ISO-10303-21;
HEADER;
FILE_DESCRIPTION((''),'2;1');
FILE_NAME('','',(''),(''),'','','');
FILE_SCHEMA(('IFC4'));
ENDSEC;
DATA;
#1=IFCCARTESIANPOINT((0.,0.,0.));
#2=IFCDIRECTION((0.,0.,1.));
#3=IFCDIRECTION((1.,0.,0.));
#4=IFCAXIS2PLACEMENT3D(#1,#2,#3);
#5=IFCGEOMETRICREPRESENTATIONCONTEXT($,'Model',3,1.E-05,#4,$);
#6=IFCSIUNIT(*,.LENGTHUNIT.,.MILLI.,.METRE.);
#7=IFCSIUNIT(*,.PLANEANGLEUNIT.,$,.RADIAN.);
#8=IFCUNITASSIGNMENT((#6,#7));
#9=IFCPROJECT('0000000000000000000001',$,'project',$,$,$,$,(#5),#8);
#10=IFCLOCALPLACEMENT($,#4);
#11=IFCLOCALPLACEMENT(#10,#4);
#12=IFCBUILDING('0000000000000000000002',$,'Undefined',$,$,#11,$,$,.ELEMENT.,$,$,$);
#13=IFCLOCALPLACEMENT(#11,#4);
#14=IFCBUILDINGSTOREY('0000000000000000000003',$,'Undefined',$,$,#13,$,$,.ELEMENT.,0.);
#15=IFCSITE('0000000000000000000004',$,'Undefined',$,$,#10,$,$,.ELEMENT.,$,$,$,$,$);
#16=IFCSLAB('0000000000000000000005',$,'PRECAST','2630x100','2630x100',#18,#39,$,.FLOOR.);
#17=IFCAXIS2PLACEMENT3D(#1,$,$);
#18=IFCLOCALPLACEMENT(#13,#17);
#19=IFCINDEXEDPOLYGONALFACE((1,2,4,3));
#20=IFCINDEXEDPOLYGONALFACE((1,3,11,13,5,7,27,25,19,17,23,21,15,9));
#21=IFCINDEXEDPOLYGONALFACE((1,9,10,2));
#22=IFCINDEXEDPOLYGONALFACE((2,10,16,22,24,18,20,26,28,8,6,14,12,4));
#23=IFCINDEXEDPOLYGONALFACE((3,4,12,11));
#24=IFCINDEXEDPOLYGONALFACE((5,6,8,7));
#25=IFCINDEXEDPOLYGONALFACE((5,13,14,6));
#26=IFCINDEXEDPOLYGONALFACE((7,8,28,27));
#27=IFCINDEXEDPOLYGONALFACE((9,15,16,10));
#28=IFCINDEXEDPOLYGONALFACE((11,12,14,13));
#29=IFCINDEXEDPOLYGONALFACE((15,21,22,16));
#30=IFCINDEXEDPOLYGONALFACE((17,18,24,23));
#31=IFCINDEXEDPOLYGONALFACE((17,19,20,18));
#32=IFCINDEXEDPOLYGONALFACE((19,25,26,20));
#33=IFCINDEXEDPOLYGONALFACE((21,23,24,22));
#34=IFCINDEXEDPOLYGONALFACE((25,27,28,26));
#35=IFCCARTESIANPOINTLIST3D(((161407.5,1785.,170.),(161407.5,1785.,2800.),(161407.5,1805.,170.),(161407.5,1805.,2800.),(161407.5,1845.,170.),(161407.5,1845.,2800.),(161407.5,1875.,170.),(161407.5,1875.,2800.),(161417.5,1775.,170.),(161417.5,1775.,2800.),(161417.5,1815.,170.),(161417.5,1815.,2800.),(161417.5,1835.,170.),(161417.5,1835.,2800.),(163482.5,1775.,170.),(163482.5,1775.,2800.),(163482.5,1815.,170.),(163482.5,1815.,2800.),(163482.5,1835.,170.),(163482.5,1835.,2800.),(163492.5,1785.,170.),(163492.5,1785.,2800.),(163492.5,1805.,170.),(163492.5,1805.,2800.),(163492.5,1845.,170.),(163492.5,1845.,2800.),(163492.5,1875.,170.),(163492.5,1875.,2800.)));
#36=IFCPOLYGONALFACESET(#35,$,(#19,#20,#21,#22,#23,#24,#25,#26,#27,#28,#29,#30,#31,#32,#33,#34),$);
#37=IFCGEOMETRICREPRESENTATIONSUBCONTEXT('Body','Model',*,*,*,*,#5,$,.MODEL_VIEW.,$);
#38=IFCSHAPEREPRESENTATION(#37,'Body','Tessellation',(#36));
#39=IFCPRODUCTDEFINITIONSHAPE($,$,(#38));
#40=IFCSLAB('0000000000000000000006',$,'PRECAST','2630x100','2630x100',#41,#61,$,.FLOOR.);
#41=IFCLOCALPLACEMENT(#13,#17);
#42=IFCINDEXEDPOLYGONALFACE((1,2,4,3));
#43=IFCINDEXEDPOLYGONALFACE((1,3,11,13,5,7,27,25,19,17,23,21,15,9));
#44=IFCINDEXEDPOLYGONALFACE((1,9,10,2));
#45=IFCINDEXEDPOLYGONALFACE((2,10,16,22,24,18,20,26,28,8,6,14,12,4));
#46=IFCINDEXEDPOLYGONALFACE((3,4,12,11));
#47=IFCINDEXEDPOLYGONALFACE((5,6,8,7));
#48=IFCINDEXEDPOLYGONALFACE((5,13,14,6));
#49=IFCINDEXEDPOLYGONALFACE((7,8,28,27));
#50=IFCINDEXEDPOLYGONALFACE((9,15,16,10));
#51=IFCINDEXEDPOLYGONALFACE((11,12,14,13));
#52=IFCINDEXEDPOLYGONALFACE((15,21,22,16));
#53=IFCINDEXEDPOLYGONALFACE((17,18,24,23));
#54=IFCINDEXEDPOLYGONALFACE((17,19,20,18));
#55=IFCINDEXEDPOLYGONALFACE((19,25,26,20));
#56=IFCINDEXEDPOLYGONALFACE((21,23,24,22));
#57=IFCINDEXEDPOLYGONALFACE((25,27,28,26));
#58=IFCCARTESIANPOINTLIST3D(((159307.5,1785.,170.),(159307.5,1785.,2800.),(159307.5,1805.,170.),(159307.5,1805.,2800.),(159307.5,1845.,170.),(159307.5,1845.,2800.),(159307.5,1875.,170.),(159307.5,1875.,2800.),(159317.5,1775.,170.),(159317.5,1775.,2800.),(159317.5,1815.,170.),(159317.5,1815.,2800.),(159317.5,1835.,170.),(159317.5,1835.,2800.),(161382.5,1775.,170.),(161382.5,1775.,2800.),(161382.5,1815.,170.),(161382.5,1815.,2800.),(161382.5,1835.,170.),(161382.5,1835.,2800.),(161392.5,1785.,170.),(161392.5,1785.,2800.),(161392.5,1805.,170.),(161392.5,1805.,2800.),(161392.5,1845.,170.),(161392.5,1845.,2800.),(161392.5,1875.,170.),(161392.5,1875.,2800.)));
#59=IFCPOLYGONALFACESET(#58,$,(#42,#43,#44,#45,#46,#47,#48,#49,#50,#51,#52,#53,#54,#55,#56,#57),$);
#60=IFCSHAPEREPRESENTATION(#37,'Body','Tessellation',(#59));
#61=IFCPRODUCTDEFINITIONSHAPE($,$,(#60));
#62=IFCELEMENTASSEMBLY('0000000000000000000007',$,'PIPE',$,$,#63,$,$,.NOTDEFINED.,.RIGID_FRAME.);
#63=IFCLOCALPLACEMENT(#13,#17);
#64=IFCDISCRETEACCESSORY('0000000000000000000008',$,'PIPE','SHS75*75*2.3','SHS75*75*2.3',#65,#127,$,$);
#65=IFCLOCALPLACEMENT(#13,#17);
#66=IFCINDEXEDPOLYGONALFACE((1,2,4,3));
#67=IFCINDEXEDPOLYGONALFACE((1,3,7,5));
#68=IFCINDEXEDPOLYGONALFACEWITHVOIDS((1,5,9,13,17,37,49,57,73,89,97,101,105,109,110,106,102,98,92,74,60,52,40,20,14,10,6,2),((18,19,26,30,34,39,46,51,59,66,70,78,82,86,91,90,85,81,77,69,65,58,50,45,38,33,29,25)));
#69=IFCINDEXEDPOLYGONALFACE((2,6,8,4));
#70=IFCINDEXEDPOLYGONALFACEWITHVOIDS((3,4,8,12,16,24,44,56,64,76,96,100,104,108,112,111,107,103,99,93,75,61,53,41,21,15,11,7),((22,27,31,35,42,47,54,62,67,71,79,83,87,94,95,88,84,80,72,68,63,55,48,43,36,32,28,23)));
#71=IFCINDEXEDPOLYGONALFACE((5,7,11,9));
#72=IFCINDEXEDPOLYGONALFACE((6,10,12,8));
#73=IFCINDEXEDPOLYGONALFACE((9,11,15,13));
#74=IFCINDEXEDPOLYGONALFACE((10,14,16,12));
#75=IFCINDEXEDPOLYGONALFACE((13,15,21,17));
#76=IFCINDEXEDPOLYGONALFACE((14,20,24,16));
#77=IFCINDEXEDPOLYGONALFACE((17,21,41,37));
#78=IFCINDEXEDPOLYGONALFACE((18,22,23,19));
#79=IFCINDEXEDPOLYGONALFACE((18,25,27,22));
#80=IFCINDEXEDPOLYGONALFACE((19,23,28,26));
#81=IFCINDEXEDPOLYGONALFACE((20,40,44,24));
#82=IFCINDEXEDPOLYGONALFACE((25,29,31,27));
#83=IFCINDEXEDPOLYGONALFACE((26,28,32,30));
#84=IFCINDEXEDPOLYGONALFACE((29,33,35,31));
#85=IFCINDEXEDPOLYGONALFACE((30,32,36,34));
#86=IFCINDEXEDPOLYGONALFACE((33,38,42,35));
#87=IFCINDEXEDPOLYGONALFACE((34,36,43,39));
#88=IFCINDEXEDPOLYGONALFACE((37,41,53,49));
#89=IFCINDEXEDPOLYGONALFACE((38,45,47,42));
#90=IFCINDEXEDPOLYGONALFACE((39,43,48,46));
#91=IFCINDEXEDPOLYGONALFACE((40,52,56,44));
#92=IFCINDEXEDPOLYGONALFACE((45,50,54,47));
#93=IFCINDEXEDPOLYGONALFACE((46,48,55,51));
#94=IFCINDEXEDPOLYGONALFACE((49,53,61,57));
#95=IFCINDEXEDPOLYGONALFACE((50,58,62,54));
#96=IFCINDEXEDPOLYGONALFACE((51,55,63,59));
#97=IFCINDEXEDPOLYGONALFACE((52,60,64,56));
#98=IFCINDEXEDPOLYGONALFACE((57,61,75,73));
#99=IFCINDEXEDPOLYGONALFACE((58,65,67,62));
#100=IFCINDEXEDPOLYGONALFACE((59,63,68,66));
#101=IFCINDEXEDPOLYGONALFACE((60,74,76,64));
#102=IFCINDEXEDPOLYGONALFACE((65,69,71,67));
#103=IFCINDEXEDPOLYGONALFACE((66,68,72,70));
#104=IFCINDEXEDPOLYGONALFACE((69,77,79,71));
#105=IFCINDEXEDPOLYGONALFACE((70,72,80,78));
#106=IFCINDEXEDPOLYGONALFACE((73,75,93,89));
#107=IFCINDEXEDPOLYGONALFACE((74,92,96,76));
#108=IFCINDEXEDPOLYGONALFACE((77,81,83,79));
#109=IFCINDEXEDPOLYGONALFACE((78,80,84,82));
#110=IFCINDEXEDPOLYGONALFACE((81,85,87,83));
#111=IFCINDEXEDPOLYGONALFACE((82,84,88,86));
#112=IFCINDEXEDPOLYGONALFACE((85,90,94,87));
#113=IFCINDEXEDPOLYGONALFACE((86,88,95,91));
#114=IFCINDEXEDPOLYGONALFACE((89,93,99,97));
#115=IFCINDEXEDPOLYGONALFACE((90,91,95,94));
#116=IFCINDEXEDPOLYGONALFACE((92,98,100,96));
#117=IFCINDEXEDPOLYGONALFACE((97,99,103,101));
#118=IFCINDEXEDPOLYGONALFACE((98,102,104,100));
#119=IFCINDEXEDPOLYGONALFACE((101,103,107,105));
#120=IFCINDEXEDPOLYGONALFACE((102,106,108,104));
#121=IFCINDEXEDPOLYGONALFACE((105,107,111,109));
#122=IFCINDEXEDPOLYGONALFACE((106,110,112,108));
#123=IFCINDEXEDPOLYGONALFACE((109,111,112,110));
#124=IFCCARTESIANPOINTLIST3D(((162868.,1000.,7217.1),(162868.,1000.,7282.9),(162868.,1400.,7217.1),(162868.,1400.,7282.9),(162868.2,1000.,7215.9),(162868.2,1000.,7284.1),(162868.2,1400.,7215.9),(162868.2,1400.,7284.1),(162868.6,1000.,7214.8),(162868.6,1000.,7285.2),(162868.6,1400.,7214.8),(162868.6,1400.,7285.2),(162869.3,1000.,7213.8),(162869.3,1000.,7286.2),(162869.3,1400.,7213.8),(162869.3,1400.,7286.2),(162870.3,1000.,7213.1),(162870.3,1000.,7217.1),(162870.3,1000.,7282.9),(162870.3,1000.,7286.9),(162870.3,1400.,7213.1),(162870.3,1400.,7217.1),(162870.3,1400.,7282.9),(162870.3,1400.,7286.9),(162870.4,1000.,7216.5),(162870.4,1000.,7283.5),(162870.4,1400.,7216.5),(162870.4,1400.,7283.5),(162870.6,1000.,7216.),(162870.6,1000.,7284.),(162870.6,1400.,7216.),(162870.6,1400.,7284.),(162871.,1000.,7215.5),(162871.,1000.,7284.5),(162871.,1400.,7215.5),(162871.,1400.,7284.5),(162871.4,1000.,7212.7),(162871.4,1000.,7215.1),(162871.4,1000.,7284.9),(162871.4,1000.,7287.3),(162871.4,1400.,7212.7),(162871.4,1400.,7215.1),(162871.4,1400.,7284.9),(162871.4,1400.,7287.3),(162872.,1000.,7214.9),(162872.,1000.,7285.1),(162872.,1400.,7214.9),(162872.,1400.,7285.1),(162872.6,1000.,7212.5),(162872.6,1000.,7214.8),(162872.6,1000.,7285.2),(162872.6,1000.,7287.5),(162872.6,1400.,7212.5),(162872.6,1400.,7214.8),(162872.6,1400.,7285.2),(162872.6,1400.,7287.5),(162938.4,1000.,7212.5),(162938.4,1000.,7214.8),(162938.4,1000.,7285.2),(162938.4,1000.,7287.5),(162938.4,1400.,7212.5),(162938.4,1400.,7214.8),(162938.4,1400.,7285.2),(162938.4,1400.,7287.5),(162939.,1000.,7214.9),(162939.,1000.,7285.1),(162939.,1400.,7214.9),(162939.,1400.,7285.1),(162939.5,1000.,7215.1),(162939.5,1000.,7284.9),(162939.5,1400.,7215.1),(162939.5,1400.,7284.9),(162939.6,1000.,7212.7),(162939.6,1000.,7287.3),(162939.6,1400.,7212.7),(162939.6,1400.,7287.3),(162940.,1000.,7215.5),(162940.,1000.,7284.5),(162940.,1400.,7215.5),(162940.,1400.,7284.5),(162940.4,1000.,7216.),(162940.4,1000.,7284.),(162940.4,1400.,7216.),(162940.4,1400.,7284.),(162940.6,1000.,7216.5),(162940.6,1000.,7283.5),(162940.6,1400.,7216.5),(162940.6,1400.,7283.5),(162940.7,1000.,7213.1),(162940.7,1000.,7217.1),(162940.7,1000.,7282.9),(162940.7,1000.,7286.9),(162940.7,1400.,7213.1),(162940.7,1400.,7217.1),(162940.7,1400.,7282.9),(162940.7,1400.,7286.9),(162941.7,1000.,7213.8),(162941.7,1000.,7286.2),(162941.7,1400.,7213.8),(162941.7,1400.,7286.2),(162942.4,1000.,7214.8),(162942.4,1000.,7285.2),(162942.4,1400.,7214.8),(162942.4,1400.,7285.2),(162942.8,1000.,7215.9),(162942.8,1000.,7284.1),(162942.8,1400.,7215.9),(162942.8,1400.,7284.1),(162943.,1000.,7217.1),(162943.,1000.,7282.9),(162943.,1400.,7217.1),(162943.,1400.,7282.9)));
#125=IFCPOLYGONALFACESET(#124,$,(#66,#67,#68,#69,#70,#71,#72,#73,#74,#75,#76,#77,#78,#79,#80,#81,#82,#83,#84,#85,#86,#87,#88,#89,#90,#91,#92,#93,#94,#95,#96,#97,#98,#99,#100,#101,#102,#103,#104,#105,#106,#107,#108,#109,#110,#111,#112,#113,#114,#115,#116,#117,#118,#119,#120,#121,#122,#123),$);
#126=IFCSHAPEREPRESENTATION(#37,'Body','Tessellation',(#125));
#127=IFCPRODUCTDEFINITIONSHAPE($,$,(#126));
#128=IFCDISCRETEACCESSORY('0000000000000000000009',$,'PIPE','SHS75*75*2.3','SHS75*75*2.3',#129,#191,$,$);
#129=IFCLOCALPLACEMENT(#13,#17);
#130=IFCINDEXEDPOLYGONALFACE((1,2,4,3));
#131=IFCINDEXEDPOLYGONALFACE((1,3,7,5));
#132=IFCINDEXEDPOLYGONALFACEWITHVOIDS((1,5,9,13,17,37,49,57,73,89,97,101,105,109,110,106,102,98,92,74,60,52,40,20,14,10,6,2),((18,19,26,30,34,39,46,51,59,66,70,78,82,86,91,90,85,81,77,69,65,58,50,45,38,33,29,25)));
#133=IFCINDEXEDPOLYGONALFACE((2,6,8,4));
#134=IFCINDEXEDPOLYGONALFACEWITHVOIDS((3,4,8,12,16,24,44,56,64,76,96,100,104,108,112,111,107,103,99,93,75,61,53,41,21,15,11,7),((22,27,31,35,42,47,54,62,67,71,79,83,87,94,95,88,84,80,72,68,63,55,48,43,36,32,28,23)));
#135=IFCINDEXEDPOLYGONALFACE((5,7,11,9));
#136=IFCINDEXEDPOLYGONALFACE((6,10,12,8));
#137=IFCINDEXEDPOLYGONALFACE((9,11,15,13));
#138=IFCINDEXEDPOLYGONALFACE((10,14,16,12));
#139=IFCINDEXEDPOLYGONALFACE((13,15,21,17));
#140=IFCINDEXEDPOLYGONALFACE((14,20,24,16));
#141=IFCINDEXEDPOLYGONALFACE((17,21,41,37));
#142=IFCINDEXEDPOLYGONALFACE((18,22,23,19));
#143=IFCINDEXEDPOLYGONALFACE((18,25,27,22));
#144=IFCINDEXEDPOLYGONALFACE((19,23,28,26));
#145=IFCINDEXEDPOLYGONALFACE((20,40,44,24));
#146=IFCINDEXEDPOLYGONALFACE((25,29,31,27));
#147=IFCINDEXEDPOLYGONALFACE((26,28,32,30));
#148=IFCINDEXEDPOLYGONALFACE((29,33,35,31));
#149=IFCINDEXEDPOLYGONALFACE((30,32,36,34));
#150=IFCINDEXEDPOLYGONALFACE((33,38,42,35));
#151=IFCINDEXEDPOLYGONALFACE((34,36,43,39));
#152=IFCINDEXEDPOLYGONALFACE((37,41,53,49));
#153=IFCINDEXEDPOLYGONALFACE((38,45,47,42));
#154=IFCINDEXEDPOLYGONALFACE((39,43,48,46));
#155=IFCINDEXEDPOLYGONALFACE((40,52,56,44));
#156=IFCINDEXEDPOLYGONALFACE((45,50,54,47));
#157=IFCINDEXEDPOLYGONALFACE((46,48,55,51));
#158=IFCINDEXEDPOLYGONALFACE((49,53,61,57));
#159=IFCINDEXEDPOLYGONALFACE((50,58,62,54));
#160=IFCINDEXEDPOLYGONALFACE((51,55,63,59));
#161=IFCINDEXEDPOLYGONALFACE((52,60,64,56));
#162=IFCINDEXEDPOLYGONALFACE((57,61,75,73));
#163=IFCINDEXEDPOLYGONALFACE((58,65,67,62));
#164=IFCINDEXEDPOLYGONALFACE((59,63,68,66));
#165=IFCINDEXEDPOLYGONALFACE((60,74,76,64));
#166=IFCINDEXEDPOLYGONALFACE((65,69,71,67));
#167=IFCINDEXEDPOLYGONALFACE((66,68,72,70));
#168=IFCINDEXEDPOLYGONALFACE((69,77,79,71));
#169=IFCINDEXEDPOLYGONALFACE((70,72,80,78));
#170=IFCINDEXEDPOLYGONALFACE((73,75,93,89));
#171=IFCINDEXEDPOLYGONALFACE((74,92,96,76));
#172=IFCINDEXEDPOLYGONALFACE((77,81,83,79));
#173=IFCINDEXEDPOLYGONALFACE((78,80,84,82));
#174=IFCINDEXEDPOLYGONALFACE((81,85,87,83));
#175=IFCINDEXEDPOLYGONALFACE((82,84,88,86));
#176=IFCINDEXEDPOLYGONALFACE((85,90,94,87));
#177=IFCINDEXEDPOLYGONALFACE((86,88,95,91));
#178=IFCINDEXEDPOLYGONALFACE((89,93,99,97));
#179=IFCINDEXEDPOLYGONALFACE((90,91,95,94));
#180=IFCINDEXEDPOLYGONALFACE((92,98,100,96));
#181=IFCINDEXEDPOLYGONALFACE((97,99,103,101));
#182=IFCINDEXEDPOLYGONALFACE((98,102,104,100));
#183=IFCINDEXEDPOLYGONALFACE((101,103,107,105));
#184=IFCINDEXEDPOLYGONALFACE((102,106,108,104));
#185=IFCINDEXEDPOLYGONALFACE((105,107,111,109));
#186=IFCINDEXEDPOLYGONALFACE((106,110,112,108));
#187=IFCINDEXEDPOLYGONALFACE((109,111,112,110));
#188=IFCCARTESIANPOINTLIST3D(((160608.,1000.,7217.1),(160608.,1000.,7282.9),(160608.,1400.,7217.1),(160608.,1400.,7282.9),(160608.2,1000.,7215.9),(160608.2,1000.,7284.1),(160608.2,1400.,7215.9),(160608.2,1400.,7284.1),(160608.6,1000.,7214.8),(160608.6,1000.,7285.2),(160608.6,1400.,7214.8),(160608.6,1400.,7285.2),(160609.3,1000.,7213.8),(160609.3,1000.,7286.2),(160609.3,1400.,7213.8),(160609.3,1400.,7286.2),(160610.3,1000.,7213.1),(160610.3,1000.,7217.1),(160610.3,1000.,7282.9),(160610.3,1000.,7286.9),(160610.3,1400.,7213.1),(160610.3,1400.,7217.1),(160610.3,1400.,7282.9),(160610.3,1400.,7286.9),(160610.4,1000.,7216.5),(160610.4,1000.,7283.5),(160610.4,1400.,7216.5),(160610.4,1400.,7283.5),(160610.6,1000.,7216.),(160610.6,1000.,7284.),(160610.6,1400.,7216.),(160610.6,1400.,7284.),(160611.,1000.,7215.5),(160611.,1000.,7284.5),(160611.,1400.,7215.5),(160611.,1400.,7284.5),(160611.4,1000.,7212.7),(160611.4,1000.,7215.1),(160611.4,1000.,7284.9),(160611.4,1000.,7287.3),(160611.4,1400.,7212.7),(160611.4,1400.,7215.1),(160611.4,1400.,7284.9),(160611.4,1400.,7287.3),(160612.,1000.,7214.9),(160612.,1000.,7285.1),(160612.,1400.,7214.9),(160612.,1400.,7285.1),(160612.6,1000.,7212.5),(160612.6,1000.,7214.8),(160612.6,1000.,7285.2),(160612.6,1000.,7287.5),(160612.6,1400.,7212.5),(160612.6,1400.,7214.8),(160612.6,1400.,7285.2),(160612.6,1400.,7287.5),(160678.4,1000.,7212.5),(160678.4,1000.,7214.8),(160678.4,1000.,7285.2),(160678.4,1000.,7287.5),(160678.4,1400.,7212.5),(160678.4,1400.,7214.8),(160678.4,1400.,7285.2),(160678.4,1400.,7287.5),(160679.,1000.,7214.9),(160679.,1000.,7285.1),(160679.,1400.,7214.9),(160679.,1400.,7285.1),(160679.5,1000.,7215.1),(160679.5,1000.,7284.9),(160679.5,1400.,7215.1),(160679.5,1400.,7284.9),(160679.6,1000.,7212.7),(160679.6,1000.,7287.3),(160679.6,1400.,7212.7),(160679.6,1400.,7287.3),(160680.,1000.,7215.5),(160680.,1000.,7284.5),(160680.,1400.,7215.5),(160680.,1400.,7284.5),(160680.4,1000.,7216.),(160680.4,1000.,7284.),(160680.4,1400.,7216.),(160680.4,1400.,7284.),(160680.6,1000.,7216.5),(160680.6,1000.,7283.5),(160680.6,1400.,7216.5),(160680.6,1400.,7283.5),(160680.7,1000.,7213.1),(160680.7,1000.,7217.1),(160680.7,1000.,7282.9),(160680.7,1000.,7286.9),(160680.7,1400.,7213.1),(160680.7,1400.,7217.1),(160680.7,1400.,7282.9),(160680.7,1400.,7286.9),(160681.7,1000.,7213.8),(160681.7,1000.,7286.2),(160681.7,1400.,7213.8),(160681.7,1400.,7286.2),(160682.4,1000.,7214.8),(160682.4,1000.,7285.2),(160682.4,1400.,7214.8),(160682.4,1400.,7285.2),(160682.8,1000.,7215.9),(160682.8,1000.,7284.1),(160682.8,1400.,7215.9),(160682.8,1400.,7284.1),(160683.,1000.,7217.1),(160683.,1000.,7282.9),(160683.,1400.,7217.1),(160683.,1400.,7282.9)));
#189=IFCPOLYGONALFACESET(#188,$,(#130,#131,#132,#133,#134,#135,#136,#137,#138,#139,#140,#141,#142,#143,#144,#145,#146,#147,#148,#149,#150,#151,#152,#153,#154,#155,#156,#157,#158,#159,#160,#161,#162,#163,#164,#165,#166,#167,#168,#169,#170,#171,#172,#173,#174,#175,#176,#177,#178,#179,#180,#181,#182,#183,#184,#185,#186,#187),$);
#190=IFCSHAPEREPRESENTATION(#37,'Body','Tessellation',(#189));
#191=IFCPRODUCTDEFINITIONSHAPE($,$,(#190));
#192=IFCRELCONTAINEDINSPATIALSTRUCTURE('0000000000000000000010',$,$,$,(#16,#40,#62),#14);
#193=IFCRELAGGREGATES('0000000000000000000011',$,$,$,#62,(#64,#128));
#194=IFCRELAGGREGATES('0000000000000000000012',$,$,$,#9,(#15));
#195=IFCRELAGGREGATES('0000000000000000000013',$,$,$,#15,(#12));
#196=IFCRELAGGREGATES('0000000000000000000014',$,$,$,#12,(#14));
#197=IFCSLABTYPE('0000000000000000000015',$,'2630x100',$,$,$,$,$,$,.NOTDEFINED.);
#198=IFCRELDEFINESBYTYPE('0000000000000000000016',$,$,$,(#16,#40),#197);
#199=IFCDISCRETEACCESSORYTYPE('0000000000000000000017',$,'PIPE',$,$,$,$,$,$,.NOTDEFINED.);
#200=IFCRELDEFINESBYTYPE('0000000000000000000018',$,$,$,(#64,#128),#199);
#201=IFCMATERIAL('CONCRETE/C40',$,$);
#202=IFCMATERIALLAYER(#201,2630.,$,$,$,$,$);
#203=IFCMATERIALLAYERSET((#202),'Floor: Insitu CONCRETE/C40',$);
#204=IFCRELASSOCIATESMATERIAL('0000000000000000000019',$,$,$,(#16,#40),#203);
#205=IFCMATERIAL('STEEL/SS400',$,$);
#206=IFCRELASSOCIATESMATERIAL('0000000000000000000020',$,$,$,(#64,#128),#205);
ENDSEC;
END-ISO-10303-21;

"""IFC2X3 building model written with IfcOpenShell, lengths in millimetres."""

from ifc_helpers import new_model, si_unit, frame, origin_with_axes, origin_2d_with_axis, place, context, subcontext, project, spatial, polyline, hollow_rectangle, outline, extrude, clip, halfspace, material, layer, layer_set, layer_usage, type_object, element, aggregate, save


model = new_model("IFC2X3")

# Units and contexts
model_context = context("Model", 3, precision=1e-05, world=origin_with_axes())
body_context = subcontext(model_context, "Body", "Model", "MODEL_VIEW")
ifc_project = project(units=[si_unit("LENGTHUNIT", "METRE", prefix="MILLI"), si_unit("PLANEANGLEUNIT", "RADIAN")], contexts=[model_context])

# Site, building, storey
site_placement = place(None, origin_with_axes())
site = spatial("IfcSite", under=ifc_project, at=site_placement, Name="Undefined", CompositionType="ELEMENT")
building_placement = place(site_placement, origin_with_axes())
building = spatial("IfcBuilding", under=site, at=building_placement, Name="Undefined", CompositionType="ELEMENT")
storey_placement = place(building_placement, origin_with_axes())
storey = spatial("IfcBuildingStorey", under=building, at=storey_placement, Name="Undefined", CompositionType="ELEMENT", Elevation=0.0)

# Slabs
ifc_material_1 = material(Name="CONCRETE/C40")
ifc_layer = layer(ifc_material_1, 2630.0)
ifc_layer_set = layer_set([ifc_layer], Name="Floor: Insitu CONCRETE/C40")
ifc_layer_usage_1 = layer_usage(ifc_layer_set, "AXIS3", "POSITIVE", -1315.0)
slab_type = type_object("IfcSlabType", Name="2630x100", PredefinedType="NOTDEFINED")
slab_1_placement = place(storey_placement, frame((163492.5, 1875.0, 1485.0), z_axis=(0.0, 0.0, 1.0), x_axis=(-1.0, 0.0, 0.0)))
element("IfcSlab", 1, at=slab_1_placement, inside=storey, type_object=slab_type, material=ifc_layer_usage_1, Name="PRECAST", Description="2630x100", ObjectType="2630x100", PredefinedType="FLOOR", context=body_context, shape_type="SweptSolid", body=[
    extrude(outline(polyline([(0.0, 0.0), (2085.0, 0.0), (2085.0, 30.0), (2075.0, 40.0), (2075.0, 60.0), (2085.0, 70.0), (2085.0, 90.0), (2075.0, 100.0), (10.0, 100.0), (0.0, 90.0), (0.0, 70.0), (10.0, 60.0), (10.0, 40.0), (0.0, 30.0), (0.0, 0.0)])), frame((0.0, 0.0, -1315.0), z_axis=(0.0, 0.0, 1.0), x_axis=(1.0, 0.0, 0.0)), (0.0, 0.0, 1.0), 2630.0),
])
ifc_layer_usage_2 = layer_usage(ifc_layer_set, "AXIS3", "POSITIVE", -1315.0)
slab_2_placement = place(storey_placement, frame((161392.5, 1875.0, 1485.0), z_axis=(0.0, 0.0, 1.0), x_axis=(-1.0, 0.0, 0.0)))
element("IfcSlab", 2, at=slab_2_placement, inside=storey, type_object=slab_type, material=ifc_layer_usage_2, Name="PRECAST", Description="2630x100", ObjectType="2630x100", PredefinedType="FLOOR", context=body_context, shape_type="SweptSolid", body=[
    extrude(outline(polyline([(0.0, 0.0), (2085.0, 0.0), (2085.0, 30.0), (2075.0, 40.0), (2075.0, 60.0), (2085.0, 70.0), (2085.0, 90.0), (2075.0, 100.0), (10.0, 100.0), (0.0, 90.0), (0.0, 70.0), (10.0, 60.0), (10.0, 40.0), (0.0, 30.0), (0.0, 0.0)])), frame((0.0, 0.0, -1315.0), z_axis=(0.0, 0.0, 1.0), x_axis=(1.0, 0.0, 0.0)), (0.0, 0.0, 1.0), 2630.0),
])

# Element assembly, discrete accessories
assembly_1_placement = place(storey_placement, origin_with_axes())
assembly_1 = element("IfcElementAssembly", 3, at=assembly_1_placement, inside=storey, Name="PIPE", AssemblyPlace="NOTDEFINED", PredefinedType="RIGID_FRAME")
ifc_material_2 = material(Name="STEEL/SS400")
discrete_accessory_type_1 = type_object("IfcDiscreteAccessoryType", Name="PIPE")
discrete_accessory_1_placement = place(assembly_1_placement, frame((162905.5, 950.0, 7250.0), z_axis=(0.0, 0.0, -1.0), x_axis=(0.0, 1.0, 0.0)))
discrete_accessory_1 = element("IfcDiscreteAccessory", 4, at=discrete_accessory_1_placement, type_object=discrete_accessory_type_1, material=ifc_material_2, Name="PIPE", Description="SHS75*75*2.3", ObjectType="SHS75*75*2.3", context=body_context, shape_type="Clipping", body=[
    clip(clip(extrude(hollow_rectangle(XDim=75.0, YDim=75.0, WallThickness=2.3, InnerFilletRadius=2.3, OuterFilletRadius=4.6, at=origin_2d_with_axis()), frame((450.0, 0.0, 0.0), z_axis=(-1.0, 0.0, 0.0), x_axis=(0.0, -1.0, 0.0)), (0.0, 0.0, 1.0), 400.0), halfspace(frame((450.0, 50.7, 0.0), z_axis=(1.0, 0.0, 0.0), x_axis=(0.0, 0.0, -1.0)), False)), halfspace(frame((50.0, 61.4, 0.0), z_axis=(1.0, 0.0, 0.0), x_axis=(0.0, 0.0, -1.0)), True)),
])
discrete_accessory_2_placement = place(assembly_1_placement, frame((160645.5, 950.0, 7250.0), z_axis=(0.0, 0.0, -1.0), x_axis=(0.0, 1.0, 0.0)))
discrete_accessory_2 = element("IfcDiscreteAccessory", 5, at=discrete_accessory_2_placement, type_object=discrete_accessory_type_1, material=ifc_material_2, Name="PIPE", Description="SHS75*75*2.3", ObjectType="SHS75*75*2.3", context=body_context, shape_type="Clipping", body=[
    clip(clip(extrude(hollow_rectangle(XDim=75.0, YDim=75.0, WallThickness=2.3, InnerFilletRadius=2.3, OuterFilletRadius=4.6, at=origin_2d_with_axis()), frame((450.0, 0.0, 0.0), z_axis=(-1.0, 0.0, 0.0), x_axis=(0.0, -1.0, 0.0)), (0.0, 0.0, 1.0), 400.0), halfspace(frame((450.0, 50.7, 0.0), z_axis=(1.0, 0.0, 0.0), x_axis=(0.0, 0.0, -1.0)), False)), halfspace(frame((50.0, 61.4, 0.0), z_axis=(1.0, 0.0, 0.0), x_axis=(0.0, 0.0, -1.0)), True)),
])

aggregate(assembly_1, [discrete_accessory_1, discrete_accessory_2])

save(model, "model.ifc")
